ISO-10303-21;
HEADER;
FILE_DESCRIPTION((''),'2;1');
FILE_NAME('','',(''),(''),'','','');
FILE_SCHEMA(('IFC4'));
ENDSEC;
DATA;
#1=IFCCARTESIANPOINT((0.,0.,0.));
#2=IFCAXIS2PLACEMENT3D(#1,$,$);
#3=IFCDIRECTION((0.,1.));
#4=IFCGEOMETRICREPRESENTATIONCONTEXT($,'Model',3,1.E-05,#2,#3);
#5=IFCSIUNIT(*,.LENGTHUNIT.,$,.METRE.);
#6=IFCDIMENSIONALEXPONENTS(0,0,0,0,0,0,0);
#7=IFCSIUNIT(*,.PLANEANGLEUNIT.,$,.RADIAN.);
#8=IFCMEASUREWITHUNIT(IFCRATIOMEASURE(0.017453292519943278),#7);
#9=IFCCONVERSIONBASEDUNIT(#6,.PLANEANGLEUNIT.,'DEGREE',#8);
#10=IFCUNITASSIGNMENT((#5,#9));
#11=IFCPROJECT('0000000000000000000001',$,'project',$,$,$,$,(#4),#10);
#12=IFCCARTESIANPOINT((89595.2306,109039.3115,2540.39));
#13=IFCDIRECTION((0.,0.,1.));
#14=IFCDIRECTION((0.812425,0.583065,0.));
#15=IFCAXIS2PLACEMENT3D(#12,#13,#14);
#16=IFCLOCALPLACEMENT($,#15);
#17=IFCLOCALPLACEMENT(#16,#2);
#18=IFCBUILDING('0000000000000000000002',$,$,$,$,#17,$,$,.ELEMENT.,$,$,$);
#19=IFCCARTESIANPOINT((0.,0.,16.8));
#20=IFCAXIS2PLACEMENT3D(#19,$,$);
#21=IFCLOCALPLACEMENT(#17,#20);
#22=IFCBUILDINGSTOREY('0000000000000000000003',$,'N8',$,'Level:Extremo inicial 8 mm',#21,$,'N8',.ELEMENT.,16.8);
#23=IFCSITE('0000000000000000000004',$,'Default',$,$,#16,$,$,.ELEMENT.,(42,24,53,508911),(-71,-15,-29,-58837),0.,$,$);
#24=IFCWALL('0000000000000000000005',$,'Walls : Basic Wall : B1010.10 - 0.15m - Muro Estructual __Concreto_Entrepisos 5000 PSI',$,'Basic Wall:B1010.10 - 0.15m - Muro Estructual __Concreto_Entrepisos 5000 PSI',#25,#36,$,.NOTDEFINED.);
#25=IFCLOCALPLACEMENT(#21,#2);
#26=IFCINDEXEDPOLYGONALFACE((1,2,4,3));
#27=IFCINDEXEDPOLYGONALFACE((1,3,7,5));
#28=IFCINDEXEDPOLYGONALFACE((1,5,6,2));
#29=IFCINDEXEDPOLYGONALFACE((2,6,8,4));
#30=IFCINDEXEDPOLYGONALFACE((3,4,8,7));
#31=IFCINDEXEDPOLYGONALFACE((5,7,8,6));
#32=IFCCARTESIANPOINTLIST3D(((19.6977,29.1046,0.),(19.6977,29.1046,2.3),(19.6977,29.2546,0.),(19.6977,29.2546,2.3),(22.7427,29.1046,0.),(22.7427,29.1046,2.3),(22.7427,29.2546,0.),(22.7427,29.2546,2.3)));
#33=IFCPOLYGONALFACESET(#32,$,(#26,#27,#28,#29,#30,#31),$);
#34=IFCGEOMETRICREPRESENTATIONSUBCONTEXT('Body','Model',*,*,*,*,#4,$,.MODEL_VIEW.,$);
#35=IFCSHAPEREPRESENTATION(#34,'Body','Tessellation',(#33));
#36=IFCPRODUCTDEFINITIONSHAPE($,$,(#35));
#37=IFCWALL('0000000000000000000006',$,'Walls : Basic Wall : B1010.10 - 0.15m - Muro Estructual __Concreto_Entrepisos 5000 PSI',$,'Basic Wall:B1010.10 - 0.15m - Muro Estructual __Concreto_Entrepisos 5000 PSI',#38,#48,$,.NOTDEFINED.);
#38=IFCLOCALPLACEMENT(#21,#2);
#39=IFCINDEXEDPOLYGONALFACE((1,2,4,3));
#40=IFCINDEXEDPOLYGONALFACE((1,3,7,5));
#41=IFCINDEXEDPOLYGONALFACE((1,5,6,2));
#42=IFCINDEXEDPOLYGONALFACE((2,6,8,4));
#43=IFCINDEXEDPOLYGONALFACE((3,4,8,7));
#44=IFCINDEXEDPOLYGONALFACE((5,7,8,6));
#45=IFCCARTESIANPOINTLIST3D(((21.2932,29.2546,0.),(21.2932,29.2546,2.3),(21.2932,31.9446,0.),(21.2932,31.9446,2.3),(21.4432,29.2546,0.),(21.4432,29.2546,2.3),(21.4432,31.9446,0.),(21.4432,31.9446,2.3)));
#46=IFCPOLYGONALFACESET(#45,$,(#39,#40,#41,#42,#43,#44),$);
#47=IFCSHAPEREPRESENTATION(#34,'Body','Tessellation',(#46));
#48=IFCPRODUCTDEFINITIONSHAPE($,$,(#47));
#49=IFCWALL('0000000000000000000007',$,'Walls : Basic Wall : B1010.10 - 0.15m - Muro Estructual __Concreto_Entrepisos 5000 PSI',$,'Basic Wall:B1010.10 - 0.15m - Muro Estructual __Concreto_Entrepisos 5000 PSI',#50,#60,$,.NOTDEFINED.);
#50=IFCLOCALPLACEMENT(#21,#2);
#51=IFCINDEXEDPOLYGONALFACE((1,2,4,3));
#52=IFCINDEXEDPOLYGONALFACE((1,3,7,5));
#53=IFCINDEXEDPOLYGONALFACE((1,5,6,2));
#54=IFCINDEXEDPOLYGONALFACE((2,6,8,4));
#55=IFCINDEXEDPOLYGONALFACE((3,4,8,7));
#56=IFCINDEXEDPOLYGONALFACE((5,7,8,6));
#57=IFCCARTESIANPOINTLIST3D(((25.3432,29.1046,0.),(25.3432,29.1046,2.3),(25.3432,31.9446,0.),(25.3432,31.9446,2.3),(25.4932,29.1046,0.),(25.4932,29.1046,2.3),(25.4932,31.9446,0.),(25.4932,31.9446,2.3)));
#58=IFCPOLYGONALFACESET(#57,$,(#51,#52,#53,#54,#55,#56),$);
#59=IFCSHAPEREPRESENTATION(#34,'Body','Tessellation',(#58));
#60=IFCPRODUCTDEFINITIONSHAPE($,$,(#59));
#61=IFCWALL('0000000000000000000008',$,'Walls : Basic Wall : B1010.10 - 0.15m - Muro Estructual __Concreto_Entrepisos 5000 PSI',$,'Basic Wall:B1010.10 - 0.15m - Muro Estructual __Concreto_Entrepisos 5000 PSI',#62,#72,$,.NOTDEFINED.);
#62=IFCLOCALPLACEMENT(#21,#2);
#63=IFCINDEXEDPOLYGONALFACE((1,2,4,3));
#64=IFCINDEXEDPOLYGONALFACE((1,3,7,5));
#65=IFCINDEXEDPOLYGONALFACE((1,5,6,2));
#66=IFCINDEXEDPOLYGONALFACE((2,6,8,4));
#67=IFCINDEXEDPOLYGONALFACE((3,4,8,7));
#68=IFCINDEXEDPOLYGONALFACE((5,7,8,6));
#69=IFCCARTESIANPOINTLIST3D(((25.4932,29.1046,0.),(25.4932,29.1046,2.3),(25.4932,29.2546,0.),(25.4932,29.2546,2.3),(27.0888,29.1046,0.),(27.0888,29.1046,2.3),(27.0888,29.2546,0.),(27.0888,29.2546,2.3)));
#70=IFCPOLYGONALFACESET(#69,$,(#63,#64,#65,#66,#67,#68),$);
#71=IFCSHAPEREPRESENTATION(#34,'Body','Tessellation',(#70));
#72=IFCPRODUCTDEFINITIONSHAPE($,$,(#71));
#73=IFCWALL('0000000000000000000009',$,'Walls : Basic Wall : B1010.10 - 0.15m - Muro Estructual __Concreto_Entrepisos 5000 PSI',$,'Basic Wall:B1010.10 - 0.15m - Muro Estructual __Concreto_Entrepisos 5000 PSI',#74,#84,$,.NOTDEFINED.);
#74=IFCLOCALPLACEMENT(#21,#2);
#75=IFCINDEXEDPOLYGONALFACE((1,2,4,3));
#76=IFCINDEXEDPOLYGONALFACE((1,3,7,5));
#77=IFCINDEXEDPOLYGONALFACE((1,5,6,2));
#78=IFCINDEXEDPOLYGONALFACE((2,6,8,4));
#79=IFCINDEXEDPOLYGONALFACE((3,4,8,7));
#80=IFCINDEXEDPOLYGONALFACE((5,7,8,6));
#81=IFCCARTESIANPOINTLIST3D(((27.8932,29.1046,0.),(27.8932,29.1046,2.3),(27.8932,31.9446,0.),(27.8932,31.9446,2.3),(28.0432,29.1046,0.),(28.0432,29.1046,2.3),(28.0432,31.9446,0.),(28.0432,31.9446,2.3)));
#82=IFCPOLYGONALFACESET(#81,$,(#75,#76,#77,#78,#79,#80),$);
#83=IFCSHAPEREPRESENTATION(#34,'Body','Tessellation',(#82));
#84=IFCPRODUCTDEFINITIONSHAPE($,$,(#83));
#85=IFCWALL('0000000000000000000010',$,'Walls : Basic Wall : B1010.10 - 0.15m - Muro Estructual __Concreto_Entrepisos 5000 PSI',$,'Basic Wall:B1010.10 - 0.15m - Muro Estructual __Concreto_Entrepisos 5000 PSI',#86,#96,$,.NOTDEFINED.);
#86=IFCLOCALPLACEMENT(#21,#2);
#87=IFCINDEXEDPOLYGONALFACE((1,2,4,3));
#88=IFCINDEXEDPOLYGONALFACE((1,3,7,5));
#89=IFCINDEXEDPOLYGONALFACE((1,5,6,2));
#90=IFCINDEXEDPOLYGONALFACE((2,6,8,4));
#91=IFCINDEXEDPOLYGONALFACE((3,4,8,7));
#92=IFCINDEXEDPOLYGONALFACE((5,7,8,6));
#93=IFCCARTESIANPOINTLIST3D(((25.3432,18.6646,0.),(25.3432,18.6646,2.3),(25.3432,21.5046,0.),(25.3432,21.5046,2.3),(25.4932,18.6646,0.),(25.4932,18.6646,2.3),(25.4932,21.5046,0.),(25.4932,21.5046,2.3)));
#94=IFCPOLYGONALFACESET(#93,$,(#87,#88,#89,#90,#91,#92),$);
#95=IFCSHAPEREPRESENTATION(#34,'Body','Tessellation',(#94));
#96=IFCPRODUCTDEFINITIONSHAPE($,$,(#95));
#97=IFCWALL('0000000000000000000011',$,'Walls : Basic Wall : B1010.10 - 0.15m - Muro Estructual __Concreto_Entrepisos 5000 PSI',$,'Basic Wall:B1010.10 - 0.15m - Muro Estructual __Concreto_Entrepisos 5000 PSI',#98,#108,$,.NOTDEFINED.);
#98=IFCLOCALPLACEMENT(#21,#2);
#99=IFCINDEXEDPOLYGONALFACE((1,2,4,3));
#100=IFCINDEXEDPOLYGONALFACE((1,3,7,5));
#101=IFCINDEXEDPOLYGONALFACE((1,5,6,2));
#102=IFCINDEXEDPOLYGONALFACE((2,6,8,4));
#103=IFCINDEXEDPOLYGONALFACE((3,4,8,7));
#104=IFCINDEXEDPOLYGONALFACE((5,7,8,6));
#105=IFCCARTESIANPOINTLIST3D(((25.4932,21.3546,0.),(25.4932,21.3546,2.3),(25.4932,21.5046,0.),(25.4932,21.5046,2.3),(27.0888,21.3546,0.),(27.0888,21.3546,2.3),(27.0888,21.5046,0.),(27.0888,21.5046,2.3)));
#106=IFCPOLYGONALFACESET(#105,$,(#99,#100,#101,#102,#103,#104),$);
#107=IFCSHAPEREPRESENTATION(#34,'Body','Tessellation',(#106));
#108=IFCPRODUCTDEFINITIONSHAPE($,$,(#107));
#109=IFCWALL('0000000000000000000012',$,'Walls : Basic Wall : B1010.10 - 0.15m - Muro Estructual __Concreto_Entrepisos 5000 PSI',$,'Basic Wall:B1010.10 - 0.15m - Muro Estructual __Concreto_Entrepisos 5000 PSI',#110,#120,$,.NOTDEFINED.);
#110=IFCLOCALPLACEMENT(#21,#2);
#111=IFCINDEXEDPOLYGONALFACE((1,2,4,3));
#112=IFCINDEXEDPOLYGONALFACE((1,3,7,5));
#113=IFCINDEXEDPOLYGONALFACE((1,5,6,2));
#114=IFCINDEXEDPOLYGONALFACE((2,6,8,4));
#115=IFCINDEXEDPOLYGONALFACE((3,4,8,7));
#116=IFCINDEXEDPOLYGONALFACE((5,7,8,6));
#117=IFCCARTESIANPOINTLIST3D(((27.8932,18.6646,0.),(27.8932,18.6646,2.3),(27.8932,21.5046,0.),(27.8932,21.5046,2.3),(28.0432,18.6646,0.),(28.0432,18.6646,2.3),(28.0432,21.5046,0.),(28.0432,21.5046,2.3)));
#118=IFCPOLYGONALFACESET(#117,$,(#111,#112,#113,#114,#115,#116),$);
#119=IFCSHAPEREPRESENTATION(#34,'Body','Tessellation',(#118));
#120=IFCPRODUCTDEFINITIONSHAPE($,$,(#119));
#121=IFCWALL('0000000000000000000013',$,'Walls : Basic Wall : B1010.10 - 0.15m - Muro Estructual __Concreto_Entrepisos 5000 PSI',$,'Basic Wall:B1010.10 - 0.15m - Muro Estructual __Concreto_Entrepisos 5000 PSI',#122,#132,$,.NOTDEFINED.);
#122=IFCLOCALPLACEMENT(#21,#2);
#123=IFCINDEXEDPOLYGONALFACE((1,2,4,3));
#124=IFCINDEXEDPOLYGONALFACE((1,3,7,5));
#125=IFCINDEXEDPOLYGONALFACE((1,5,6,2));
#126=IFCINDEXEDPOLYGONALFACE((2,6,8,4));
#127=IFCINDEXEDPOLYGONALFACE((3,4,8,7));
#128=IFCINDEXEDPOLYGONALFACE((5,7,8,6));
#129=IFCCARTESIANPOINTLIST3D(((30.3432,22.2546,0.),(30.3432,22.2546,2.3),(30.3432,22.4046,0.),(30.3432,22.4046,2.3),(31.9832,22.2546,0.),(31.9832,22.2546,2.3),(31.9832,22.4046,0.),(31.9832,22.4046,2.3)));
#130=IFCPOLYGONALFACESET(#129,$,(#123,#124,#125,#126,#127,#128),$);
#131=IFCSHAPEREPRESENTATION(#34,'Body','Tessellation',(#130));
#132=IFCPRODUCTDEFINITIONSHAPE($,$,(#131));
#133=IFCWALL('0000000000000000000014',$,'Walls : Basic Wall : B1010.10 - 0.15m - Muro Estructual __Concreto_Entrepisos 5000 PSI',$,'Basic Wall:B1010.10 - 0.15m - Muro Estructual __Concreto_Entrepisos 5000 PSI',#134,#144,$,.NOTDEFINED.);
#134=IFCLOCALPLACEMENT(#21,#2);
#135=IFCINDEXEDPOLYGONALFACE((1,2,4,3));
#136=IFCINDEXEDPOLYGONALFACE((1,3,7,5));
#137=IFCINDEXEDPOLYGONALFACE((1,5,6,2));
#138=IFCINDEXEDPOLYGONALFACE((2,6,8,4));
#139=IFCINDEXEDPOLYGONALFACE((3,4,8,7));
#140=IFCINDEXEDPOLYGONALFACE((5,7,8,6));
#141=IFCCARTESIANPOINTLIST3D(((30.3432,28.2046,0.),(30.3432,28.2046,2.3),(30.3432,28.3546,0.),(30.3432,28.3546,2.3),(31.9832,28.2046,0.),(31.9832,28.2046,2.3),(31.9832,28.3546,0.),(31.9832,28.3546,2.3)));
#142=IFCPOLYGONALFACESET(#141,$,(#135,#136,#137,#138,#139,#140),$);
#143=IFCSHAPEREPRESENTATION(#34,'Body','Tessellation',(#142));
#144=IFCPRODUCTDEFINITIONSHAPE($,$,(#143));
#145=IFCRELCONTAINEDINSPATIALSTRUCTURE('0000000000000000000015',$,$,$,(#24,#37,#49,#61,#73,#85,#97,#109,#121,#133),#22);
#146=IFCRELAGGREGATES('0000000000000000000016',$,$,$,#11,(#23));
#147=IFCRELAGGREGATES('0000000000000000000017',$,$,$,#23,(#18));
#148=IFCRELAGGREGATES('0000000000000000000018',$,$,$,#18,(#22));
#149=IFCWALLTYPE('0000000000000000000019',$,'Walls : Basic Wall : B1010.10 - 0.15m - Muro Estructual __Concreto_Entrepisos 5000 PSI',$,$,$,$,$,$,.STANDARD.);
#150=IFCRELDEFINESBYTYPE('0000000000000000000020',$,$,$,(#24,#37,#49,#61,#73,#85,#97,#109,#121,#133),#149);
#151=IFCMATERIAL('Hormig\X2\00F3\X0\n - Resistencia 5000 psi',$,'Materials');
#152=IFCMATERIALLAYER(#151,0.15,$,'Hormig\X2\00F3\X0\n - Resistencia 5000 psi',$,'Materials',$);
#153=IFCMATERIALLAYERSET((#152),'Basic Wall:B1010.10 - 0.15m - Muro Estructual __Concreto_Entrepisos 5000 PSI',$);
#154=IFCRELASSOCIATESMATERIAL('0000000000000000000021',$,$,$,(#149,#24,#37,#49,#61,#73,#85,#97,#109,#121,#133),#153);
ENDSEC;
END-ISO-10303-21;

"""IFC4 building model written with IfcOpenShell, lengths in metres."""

from ifc_helpers import new_model, entity, si_unit, converted_unit, direction, frame, frame_2d, origin, place, context, subcontext, project, spatial, rectangle, extrude, material, layer, layer_set, layer_usage, type_object, element, save


model = new_model("IFC4")

# Units and contexts
model_context = context("Model", 3, precision=1e-05, world=origin(), true_north=direction((0.0, 1.0)))
body_context = subcontext(model_context, "Body", "Model", "MODEL_VIEW")
ifc_project = project(units=[si_unit("LENGTHUNIT", "METRE"), converted_unit("PLANEANGLEUNIT", "DEGREE", entity("IfcRatioMeasure", 0.017453292519943278), si_unit("PLANEANGLEUNIT", "RADIAN"), dimensions=[0, 0, 0, 0, 0, 0, 0])], contexts=[model_context])

# Site, building, storey
site_placement = place(None, frame((89595.2306, 109039.3115, 2540.39), z_axis=(0.0, 0.0, 1.0), x_axis=(0.812425, 0.583065, 0.0)))
site = spatial("IfcSite", under=ifc_project, at=site_placement, Name="Default", CompositionType="ELEMENT", RefLatitude=(42, 24, 53, 508911), RefLongitude=(-71, -15, -29, -58837), RefElevation=0.0)
building_placement = place(site_placement, origin())
building = spatial("IfcBuilding", under=site, at=building_placement, CompositionType="ELEMENT")
storey_placement = place(building_placement, frame((0.0, 0.0, 16.8)))
storey = spatial("IfcBuildingStorey", under=building, at=storey_placement, Name="N8", ObjectType="Level:Extremo inicial 8 mm", LongName="N8", CompositionType="ELEMENT", Elevation=16.8)

# Walls
ifc_material_1 = material(Name="Hormigón - Resistencia 5000 psi", Category="Materials")
ifc_layer_1 = layer(ifc_material_1, 0.15, Name="Hormigón - Resistencia 5000 psi", Category="Materials")
ifc_layer_set_1 = layer_set([ifc_layer_1], Name="Basic Wall:B1010.10 - 0.15m - Muro Estructual __Concreto_Entrepisos 5000 PSI")
wall_type_1 = type_object("IfcWallType", Name="Walls : Basic Wall : B1010.10 - 0.15m - Muro Estructual __Concreto_Entrepisos 5000 PSI", PredefinedType="STANDARD", material=ifc_layer_set_1)
ifc_layer_usage_1 = layer_usage(ifc_layer_set_1, "AXIS2", "NEGATIVE", 0.075)
wall_1_placement = place(storey_placement, frame((19.6977, 29.1796, 0.0)))
element("IfcWall", 1, at=wall_1_placement, inside=storey, type_object=wall_type_1, material=ifc_layer_usage_1, Name="Walls : Basic Wall : B1010.10 - 0.15m - Muro Estructual __Concreto_Entrepisos 5000 PSI", ObjectType="Basic Wall:B1010.10 - 0.15m - Muro Estructual __Concreto_Entrepisos 5000 PSI", PredefinedType="NOTDEFINED", context=body_context, shape_type="SweptSolid", body=[
    extrude(rectangle(XDim=3.045, YDim=0.15, at=frame_2d((1.5225, 0.0), x_axis=(-1.0, 0.0))), origin(), (0.0, 0.0, 1.0), 2.3),
])
ifc_layer_usage_2 = layer_usage(ifc_layer_set_1, "AXIS2", "NEGATIVE", 0.075)
wall_2_placement = place(storey_placement, frame((21.3682, 31.9446, 0.0), z_axis=(0.0, 0.0, 1.0), x_axis=(0.0, -1.0, 0.0)))
element("IfcWall", 2, at=wall_2_placement, inside=storey, type_object=wall_type_1, material=ifc_layer_usage_2, Name="Walls : Basic Wall : B1010.10 - 0.15m - Muro Estructual __Concreto_Entrepisos 5000 PSI", ObjectType="Basic Wall:B1010.10 - 0.15m - Muro Estructual __Concreto_Entrepisos 5000 PSI", PredefinedType="NOTDEFINED", context=body_context, shape_type="SweptSolid", body=[
    extrude(rectangle(XDim=2.69, YDim=0.15, at=frame_2d((1.345, 0.0), x_axis=(-1.0, 0.0))), origin(), (0.0, 0.0, 1.0), 2.3),
])
ifc_layer_usage_3 = layer_usage(ifc_layer_set_1, "AXIS2", "NEGATIVE", 0.075)
wall_3_placement = place(storey_placement, frame((25.4182, 31.9446, 0.0), z_axis=(0.0, 0.0, 1.0), x_axis=(0.0, -1.0, 0.0)))
element("IfcWall", 3, at=wall_3_placement, inside=storey, type_object=wall_type_1, material=ifc_layer_usage_3, Name="Walls : Basic Wall : B1010.10 - 0.15m - Muro Estructual __Concreto_Entrepisos 5000 PSI", ObjectType="Basic Wall:B1010.10 - 0.15m - Muro Estructual __Concreto_Entrepisos 5000 PSI", PredefinedType="NOTDEFINED", context=body_context, shape_type="SweptSolid", body=[
    extrude(rectangle(XDim=2.84, YDim=0.15, at=frame_2d((1.42, 0.0), x_axis=(-1.0, 0.0))), origin(), (0.0, 0.0, 1.0), 2.3),
])
ifc_layer_usage_4 = layer_usage(ifc_layer_set_1, "AXIS2", "NEGATIVE", 0.075)
wall_4_placement = place(storey_placement, frame((27.0888, 29.1796, 0.0), z_axis=(0.0, 0.0, 1.0), x_axis=(-1.0, 0.0, 0.0)))
element("IfcWall", 4, at=wall_4_placement, inside=storey, type_object=wall_type_1, material=ifc_layer_usage_4, Name="Walls : Basic Wall : B1010.10 - 0.15m - Muro Estructual __Concreto_Entrepisos 5000 PSI", ObjectType="Basic Wall:B1010.10 - 0.15m - Muro Estructual __Concreto_Entrepisos 5000 PSI", PredefinedType="NOTDEFINED", context=body_context, shape_type="SweptSolid", body=[
    extrude(rectangle(XDim=1.5955, YDim=0.15, at=frame_2d((0.7978, 0.0), x_axis=(-1.0, 0.0))), origin(), (0.0, 0.0, 1.0), 2.3),
])
ifc_layer_usage_5 = layer_usage(ifc_layer_set_1, "AXIS2", "NEGATIVE", 0.075)
wall_5_placement = place(storey_placement, frame((27.9682, 31.9446, 0.0), z_axis=(0.0, 0.0, 1.0), x_axis=(0.0, -1.0, 0.0)))
element("IfcWall", 5, at=wall_5_placement, inside=storey, type_object=wall_type_1, material=ifc_layer_usage_5, Name="Walls : Basic Wall : B1010.10 - 0.15m - Muro Estructual __Concreto_Entrepisos 5000 PSI", ObjectType="Basic Wall:B1010.10 - 0.15m - Muro Estructual __Concreto_Entrepisos 5000 PSI", PredefinedType="NOTDEFINED", context=body_context, shape_type="SweptSolid", body=[
    extrude(rectangle(XDim=2.84, YDim=0.15, at=frame_2d((1.42, 0.0), x_axis=(-1.0, 0.0))), origin(), (0.0, 0.0, 1.0), 2.3),
])
ifc_layer_usage_6 = layer_usage(ifc_layer_set_1, "AXIS2", "NEGATIVE", 0.075)
wall_6_placement = place(storey_placement, frame((25.4182, 18.6646, 0.0), z_axis=(0.0, 0.0, 1.0), x_axis=(0.0, 1.0, 0.0)))
element("IfcWall", 6, at=wall_6_placement, inside=storey, type_object=wall_type_1, material=ifc_layer_usage_6, Name="Walls : Basic Wall : B1010.10 - 0.15m - Muro Estructual __Concreto_Entrepisos 5000 PSI", ObjectType="Basic Wall:B1010.10 - 0.15m - Muro Estructual __Concreto_Entrepisos 5000 PSI", PredefinedType="NOTDEFINED", context=body_context, shape_type="SweptSolid", body=[
    extrude(rectangle(XDim=2.84, YDim=0.15, at=frame_2d((1.42, 0.0), x_axis=(-1.0, 0.0))), origin(), (0.0, 0.0, 1.0), 2.3),
])
ifc_layer_usage_7 = layer_usage(ifc_layer_set_1, "AXIS2", "NEGATIVE", 0.075)
wall_7_placement = place(storey_placement, frame((27.0888, 21.4296, 0.0), z_axis=(0.0, 0.0, 1.0), x_axis=(-1.0, 0.0, 0.0)))
element("IfcWall", 7, at=wall_7_placement, inside=storey, type_object=wall_type_1, material=ifc_layer_usage_7, Name="Walls : Basic Wall : B1010.10 - 0.15m - Muro Estructual __Concreto_Entrepisos 5000 PSI", ObjectType="Basic Wall:B1010.10 - 0.15m - Muro Estructual __Concreto_Entrepisos 5000 PSI", PredefinedType="NOTDEFINED", context=body_context, shape_type="SweptSolid", body=[
    extrude(rectangle(XDim=1.5955, YDim=0.15, at=frame_2d((0.7978, 0.0), x_axis=(-1.0, 0.0))), origin(), (0.0, 0.0, 1.0), 2.3),
])
ifc_layer_usage_8 = layer_usage(ifc_layer_set_1, "AXIS2", "NEGATIVE", 0.075)
wall_8_placement = place(storey_placement, frame((27.9682, 18.6646, 0.0), z_axis=(0.0, 0.0, 1.0), x_axis=(0.0, 1.0, 0.0)))
element("IfcWall", 8, at=wall_8_placement, inside=storey, type_object=wall_type_1, material=ifc_layer_usage_8, Name="Walls : Basic Wall : B1010.10 - 0.15m - Muro Estructual __Concreto_Entrepisos 5000 PSI", ObjectType="Basic Wall:B1010.10 - 0.15m - Muro Estructual __Concreto_Entrepisos 5000 PSI", PredefinedType="NOTDEFINED", context=body_context, shape_type="SweptSolid", body=[
    extrude(rectangle(XDim=2.84, YDim=0.15, at=frame_2d((1.42, 0.0), x_axis=(-1.0, 0.0))), origin(), (0.0, 0.0, 1.0), 2.3),
])
ifc_layer_usage_9 = layer_usage(ifc_layer_set_1, "AXIS2", "NEGATIVE", 0.075)
wall_9_placement = place(storey_placement, frame((31.9832, 22.3296, 0.0), z_axis=(0.0, 0.0, 1.0), x_axis=(-1.0, 0.0, 0.0)))
element("IfcWall", 9, at=wall_9_placement, inside=storey, type_object=wall_type_1, material=ifc_layer_usage_9, Name="Walls : Basic Wall : B1010.10 - 0.15m - Muro Estructual __Concreto_Entrepisos 5000 PSI", ObjectType="Basic Wall:B1010.10 - 0.15m - Muro Estructual __Concreto_Entrepisos 5000 PSI", PredefinedType="NOTDEFINED", context=body_context, shape_type="SweptSolid", body=[
    extrude(rectangle(XDim=1.64, YDim=0.15, at=frame_2d((0.82, 0.0), x_axis=(-1.0, 0.0))), origin(), (0.0, 0.0, 1.0), 2.3),
])
ifc_layer_usage_10 = layer_usage(ifc_layer_set_1, "AXIS2", "POSITIVE", -0.075)
wall_10_placement = place(storey_placement, frame((31.9832, 28.2796, 0.0), z_axis=(0.0, 0.0, 1.0), x_axis=(-1.0, 0.0, 0.0)))
element("IfcWall", 10, at=wall_10_placement, inside=storey, type_object=wall_type_1, material=ifc_layer_usage_10, Name="Walls : Basic Wall : B1010.10 - 0.15m - Muro Estructual __Concreto_Entrepisos 5000 PSI", ObjectType="Basic Wall:B1010.10 - 0.15m - Muro Estructual __Concreto_Entrepisos 5000 PSI", PredefinedType="NOTDEFINED", context=body_context, shape_type="SweptSolid", body=[
    extrude(rectangle(XDim=1.64, YDim=0.15, at=frame_2d((0.82, 0.0), x_axis=(-1.0, 0.0))), origin(), (0.0, 0.0, 1.0), 2.3),
])

save(model, "model.ifc")
